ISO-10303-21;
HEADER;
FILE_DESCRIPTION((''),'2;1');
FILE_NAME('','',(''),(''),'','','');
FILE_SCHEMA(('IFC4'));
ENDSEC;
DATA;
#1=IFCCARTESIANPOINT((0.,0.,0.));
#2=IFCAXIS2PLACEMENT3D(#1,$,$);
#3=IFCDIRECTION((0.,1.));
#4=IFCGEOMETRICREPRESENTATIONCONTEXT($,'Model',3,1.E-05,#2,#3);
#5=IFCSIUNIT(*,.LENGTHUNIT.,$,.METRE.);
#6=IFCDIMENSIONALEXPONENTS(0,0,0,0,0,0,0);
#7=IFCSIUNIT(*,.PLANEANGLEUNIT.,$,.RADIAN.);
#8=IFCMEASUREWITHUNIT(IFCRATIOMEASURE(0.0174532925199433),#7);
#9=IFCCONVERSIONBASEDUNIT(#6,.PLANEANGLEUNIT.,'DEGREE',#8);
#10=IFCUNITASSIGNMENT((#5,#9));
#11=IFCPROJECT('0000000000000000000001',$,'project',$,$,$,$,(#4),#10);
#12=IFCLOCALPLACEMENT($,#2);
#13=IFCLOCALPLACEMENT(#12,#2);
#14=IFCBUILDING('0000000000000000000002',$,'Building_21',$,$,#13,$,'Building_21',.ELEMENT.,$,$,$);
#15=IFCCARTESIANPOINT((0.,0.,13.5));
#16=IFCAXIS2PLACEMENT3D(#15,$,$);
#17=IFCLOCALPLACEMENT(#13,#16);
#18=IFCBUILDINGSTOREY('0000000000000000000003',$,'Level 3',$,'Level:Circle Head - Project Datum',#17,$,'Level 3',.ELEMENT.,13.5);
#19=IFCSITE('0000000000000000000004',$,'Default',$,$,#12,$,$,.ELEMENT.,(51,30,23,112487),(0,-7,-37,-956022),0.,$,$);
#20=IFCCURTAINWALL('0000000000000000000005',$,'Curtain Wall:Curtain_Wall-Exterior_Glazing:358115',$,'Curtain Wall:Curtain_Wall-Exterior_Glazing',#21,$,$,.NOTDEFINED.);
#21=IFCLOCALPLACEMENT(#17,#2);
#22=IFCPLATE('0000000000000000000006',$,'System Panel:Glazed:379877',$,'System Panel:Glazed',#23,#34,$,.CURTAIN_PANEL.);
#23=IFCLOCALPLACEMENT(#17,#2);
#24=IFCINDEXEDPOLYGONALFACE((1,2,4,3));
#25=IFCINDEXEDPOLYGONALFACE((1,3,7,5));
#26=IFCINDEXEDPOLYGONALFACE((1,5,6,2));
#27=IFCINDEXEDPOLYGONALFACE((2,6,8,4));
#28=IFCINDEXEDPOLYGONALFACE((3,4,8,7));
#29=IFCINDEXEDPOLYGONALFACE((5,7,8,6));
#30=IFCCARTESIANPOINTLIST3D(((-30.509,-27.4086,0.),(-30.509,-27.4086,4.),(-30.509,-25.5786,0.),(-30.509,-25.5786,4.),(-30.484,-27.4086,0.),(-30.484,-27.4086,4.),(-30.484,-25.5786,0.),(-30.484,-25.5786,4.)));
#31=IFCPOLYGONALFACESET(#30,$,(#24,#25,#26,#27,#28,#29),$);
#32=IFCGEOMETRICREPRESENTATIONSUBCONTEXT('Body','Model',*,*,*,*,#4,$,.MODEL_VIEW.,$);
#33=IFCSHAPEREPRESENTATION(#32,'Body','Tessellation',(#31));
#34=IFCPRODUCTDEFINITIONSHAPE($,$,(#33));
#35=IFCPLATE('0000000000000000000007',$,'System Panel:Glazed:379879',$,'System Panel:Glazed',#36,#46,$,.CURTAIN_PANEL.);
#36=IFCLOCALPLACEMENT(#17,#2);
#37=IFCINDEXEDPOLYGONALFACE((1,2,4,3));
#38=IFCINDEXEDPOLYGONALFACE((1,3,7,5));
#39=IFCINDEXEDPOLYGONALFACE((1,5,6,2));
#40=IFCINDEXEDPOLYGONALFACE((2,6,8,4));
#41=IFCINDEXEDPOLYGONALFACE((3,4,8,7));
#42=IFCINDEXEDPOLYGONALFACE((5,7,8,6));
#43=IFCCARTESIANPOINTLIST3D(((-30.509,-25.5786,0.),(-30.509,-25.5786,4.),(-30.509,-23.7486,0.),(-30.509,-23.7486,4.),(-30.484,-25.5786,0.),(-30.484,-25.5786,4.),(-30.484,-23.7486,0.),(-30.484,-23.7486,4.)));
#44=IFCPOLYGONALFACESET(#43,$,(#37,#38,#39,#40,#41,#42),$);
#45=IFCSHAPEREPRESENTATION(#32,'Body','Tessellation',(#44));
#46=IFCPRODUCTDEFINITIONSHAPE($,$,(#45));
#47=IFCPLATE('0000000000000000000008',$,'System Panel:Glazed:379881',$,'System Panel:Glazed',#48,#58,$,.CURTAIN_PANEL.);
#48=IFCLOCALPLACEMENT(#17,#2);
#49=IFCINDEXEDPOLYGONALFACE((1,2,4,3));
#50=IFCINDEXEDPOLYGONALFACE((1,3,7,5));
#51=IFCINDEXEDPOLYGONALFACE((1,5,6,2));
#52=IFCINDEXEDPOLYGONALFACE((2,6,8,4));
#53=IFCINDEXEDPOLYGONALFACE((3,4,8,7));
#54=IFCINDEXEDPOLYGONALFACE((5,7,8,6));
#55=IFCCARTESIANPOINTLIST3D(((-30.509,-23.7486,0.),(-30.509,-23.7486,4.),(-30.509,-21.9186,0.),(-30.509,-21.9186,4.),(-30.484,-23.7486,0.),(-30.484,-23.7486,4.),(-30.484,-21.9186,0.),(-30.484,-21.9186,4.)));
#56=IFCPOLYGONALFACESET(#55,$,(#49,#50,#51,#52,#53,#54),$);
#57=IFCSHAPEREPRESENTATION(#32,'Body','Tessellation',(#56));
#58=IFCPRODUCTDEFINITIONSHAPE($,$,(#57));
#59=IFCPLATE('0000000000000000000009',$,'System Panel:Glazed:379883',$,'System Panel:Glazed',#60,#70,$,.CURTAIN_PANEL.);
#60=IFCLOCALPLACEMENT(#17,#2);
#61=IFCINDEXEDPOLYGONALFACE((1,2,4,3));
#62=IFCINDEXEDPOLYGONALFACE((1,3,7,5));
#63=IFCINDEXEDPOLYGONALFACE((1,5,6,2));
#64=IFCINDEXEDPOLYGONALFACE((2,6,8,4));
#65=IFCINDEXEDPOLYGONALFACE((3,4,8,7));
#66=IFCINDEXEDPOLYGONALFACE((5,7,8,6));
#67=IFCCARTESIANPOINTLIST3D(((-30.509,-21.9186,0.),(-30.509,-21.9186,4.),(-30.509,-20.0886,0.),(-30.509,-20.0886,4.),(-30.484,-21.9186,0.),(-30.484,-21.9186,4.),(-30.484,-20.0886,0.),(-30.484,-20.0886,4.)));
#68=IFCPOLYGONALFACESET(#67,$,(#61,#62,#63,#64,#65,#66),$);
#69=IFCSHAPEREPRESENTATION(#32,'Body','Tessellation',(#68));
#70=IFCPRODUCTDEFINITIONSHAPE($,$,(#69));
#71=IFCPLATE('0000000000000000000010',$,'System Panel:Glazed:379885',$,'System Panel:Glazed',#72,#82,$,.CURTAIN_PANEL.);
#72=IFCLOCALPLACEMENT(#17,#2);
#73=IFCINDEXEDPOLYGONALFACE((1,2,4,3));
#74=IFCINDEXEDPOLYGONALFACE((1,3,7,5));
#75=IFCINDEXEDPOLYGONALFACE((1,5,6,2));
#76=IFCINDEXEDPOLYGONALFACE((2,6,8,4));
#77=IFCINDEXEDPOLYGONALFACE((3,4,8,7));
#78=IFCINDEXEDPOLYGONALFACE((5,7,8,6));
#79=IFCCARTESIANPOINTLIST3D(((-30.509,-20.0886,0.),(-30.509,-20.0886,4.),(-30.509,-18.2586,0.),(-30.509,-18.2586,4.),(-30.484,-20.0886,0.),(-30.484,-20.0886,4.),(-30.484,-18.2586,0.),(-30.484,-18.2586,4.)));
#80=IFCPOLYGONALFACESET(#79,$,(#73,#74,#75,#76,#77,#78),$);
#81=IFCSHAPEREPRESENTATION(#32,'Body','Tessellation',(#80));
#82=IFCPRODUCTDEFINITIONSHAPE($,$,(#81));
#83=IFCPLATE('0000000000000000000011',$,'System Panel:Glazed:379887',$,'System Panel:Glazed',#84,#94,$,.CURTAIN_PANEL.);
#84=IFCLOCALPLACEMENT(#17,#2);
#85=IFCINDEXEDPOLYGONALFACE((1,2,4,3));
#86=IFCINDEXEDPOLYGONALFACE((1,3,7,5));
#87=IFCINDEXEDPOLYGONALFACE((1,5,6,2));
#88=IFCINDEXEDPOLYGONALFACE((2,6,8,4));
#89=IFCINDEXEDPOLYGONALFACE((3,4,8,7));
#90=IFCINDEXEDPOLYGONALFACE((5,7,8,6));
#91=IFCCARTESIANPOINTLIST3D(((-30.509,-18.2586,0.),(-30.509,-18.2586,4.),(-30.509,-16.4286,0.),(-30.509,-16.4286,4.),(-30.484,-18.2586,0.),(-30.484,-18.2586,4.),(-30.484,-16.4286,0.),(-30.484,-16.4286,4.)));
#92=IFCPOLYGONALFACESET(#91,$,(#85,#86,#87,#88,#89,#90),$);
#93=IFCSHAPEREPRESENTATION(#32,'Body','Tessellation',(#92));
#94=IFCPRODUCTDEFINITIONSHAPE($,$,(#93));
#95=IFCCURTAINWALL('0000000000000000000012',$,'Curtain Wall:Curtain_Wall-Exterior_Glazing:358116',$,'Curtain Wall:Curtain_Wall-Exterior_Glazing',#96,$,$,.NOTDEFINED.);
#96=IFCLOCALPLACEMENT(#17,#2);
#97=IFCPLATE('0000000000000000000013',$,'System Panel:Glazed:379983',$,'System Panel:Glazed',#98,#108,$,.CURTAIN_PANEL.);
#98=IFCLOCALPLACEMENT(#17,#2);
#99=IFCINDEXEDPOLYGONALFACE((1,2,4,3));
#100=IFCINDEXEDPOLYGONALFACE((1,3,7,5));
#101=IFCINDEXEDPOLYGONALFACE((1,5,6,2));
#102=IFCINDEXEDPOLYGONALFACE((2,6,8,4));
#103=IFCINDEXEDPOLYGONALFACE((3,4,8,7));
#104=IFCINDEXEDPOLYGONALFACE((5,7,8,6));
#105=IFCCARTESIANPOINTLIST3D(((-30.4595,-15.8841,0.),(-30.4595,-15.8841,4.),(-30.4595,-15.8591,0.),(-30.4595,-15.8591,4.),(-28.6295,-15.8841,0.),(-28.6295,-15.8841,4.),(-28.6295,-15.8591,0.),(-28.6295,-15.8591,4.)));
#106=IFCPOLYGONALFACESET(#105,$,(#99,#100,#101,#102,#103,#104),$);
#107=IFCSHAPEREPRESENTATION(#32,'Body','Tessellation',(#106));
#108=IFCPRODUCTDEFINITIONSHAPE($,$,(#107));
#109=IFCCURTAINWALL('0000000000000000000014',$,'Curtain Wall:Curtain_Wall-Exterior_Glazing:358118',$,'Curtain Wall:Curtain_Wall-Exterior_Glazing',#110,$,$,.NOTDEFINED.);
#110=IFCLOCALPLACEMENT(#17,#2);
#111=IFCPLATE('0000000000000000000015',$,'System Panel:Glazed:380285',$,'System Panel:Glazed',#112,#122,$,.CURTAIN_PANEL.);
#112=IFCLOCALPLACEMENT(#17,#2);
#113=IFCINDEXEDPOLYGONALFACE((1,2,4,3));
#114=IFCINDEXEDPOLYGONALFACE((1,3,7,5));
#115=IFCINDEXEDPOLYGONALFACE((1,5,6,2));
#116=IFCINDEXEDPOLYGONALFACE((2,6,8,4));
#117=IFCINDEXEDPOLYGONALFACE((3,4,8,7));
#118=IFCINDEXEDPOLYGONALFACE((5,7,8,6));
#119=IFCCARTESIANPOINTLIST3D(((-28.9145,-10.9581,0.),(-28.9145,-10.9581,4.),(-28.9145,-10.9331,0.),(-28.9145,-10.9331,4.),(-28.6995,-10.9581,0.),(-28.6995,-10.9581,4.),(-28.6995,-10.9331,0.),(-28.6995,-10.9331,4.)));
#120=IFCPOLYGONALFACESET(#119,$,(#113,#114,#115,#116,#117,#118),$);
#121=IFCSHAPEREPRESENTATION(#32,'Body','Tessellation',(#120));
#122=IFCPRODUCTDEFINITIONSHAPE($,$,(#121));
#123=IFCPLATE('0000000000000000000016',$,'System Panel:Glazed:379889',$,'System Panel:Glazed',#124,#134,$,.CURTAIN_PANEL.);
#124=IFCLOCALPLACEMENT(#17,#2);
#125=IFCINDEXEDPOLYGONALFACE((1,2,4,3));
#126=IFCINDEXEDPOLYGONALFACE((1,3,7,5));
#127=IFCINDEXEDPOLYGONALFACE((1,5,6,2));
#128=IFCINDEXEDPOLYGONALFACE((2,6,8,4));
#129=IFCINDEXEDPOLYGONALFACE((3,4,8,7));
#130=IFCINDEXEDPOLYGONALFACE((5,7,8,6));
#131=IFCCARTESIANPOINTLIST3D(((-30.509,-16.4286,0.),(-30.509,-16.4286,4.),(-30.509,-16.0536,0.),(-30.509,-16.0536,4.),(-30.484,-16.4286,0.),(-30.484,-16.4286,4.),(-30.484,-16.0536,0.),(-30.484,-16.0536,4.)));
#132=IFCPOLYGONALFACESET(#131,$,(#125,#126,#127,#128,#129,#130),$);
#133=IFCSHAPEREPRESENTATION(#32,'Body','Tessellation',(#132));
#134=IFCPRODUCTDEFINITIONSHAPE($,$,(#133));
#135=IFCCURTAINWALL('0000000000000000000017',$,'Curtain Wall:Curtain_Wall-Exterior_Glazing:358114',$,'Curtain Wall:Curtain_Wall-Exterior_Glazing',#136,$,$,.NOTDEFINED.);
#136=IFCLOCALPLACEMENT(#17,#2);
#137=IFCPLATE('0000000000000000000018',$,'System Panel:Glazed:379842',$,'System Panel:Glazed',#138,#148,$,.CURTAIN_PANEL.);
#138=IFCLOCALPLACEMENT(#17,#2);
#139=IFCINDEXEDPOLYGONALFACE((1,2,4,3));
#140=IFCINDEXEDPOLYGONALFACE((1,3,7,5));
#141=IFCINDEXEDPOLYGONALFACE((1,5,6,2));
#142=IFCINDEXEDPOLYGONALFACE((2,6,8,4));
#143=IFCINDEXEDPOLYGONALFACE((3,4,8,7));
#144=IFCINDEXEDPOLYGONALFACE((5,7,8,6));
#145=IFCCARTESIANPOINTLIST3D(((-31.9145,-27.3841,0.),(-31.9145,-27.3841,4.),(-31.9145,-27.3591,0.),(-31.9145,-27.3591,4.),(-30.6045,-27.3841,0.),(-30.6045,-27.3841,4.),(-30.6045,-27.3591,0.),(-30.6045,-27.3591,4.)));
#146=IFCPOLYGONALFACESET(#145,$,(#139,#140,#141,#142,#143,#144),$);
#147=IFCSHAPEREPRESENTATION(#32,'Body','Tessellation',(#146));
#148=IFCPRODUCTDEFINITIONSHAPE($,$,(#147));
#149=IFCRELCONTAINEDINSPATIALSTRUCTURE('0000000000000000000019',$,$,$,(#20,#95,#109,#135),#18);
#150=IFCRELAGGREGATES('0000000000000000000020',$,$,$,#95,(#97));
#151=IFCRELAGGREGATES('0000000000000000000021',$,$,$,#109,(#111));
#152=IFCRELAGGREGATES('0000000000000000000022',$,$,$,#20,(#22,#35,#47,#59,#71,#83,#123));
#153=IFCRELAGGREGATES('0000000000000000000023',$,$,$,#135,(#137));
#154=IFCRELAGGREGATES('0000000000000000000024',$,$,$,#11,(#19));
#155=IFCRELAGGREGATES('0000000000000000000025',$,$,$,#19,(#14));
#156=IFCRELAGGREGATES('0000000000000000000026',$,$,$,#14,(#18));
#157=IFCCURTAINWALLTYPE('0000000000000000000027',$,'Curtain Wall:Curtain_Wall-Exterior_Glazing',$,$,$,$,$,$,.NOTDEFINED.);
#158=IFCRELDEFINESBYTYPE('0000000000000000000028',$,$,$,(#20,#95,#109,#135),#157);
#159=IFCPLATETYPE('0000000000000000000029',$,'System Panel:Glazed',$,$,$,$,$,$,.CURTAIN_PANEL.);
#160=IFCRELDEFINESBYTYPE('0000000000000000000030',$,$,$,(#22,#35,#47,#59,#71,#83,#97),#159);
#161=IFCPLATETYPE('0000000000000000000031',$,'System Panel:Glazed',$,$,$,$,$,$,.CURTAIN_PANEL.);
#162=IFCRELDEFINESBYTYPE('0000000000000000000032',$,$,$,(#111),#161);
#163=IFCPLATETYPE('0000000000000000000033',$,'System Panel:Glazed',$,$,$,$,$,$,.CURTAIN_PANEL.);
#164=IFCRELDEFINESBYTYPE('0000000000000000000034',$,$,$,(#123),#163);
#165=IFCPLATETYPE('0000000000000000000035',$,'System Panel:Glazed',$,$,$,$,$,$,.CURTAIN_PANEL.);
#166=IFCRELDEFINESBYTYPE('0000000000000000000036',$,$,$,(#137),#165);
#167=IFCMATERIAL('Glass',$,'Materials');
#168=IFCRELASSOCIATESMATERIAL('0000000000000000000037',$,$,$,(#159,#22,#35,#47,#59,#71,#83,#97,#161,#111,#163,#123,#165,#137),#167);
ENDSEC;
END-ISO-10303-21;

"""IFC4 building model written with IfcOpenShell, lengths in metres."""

from ifc_helpers import new_model, entity, si_unit, converted_unit, direction, frame, origin, origin_2d_with_axis, place, context, subcontext, project, spatial, rectangle, extrude, source, transform, mapped, material, type_object, type_shapes, element, aggregate, save


model = new_model("IFC4")

# Units and contexts
model_context = context("Model", 3, precision=1e-05, world=origin(), true_north=direction((0.0, 1.0)))
body_context = subcontext(model_context, "Body", "Model", "MODEL_VIEW")
ifc_project = project(units=[si_unit("LENGTHUNIT", "METRE"), converted_unit("PLANEANGLEUNIT", "DEGREE", entity("IfcRatioMeasure", 0.0174532925199433), si_unit("PLANEANGLEUNIT", "RADIAN"), dimensions=[0, 0, 0, 0, 0, 0, 0])], contexts=[model_context])

# Site, building, storey
site_placement = place(None, origin())
site = spatial("IfcSite", under=ifc_project, at=site_placement, Name="Default", CompositionType="ELEMENT", RefLatitude=(51, 30, 23, 112487), RefLongitude=(0, -7, -37, -956022), RefElevation=0.0)
building_placement = place(site_placement, origin())
building = spatial("IfcBuilding", under=site, at=building_placement, Name="Building_21", LongName="Building_21", CompositionType="ELEMENT")
storey_placement = place(building_placement, frame((0.0, 0.0, 13.5)))
storey = spatial("IfcBuildingStorey", under=building, at=storey_placement, Name="Level 3", ObjectType="Level:Circle Head - Project Datum", LongName="Level 3", CompositionType="ELEMENT", Elevation=13.5)

# Curtain wall, plates
curtain_wall_type = type_object("IfcCurtainWallType", Name="Curtain Wall:Curtain_Wall-Exterior_Glazing", PredefinedType="NOTDEFINED")
curtain_wall_1_placement = place(storey_placement, frame((0.0, 0.0, -13.5)))
curtain_wall_1 = element("IfcCurtainWall", 1, at=curtain_wall_1_placement, inside=storey, type_object=curtain_wall_type, Name="Curtain Wall:Curtain_Wall-Exterior_Glazing:358115", ObjectType="Curtain Wall:Curtain_Wall-Exterior_Glazing", PredefinedType="NOTDEFINED")
ifc_material_1 = material(Name="Glass", Category="Materials")
plate_type_1 = type_object("IfcPlateType", Name="System Panel:Glazed", PredefinedType="CURTAIN_PANEL", material=ifc_material_1)
shared_shape_1 = source(origin(), body_context, "Body", "SweptSolid", [
    extrude(rectangle(XDim=0.025, YDim=1.83, at=origin_2d_with_axis()), frame((0.915, 0.0125, 0.0), z_axis=(0.0, 0.0, 1.0), x_axis=(0.0, 1.0, 0.0)), (0.0, 0.0, 1.0), 4.0),
])
type_shapes(plate_type_1, [shared_shape_1])
plate_1_placement = place(curtain_wall_1_placement, frame((-30.484, -27.4086, 13.5), z_axis=(0.0, 0.0, 1.0), x_axis=(0.0, 1.0, 0.0)))
plate_1 = element("IfcPlate", 2, at=plate_1_placement, type_object=plate_type_1, material=ifc_material_1, Name="System Panel:Glazed:379877", ObjectType="System Panel:Glazed", PredefinedType="CURTAIN_PANEL", context=body_context, shape_type="MappedRepresentation", body=[
    mapped(shared_shape_1, transform((0.0, 0.0, 0.0), scale=1.0)),
])
plate_2_placement = place(curtain_wall_1_placement, frame((-30.484, -25.5786, 13.5), z_axis=(0.0, 0.0, 1.0), x_axis=(0.0, 1.0, 0.0)))
plate_2 = element("IfcPlate", 3, at=plate_2_placement, type_object=plate_type_1, material=ifc_material_1, Name="System Panel:Glazed:379879", ObjectType="System Panel:Glazed", PredefinedType="CURTAIN_PANEL", context=body_context, shape_type="MappedRepresentation", body=[
    mapped(shared_shape_1, transform((0.0, 0.0, 0.0), scale=1.0)),
])
plate_3_placement = place(curtain_wall_1_placement, frame((-30.484, -23.7486, 13.5), z_axis=(0.0, 0.0, 1.0), x_axis=(0.0, 1.0, 0.0)))
plate_3 = element("IfcPlate", 4, at=plate_3_placement, type_object=plate_type_1, material=ifc_material_1, Name="System Panel:Glazed:379881", ObjectType="System Panel:Glazed", PredefinedType="CURTAIN_PANEL", context=body_context, shape_type="MappedRepresentation", body=[
    mapped(shared_shape_1, transform((0.0, 0.0, 0.0), scale=1.0)),
])
plate_4_placement = place(curtain_wall_1_placement, frame((-30.484, -21.9186, 13.5), z_axis=(0.0, 0.0, 1.0), x_axis=(0.0, 1.0, 0.0)))
plate_4 = element("IfcPlate", 5, at=plate_4_placement, type_object=plate_type_1, material=ifc_material_1, Name="System Panel:Glazed:379883", ObjectType="System Panel:Glazed", PredefinedType="CURTAIN_PANEL", context=body_context, shape_type="MappedRepresentation", body=[
    mapped(shared_shape_1, transform((0.0, 0.0, 0.0), scale=1.0)),
])
plate_5_placement = place(curtain_wall_1_placement, frame((-30.484, -20.0886, 13.5), z_axis=(0.0, 0.0, 1.0), x_axis=(0.0, 1.0, 0.0)))
plate_5 = element("IfcPlate", 6, at=plate_5_placement, type_object=plate_type_1, material=ifc_material_1, Name="System Panel:Glazed:379885", ObjectType="System Panel:Glazed", PredefinedType="CURTAIN_PANEL", context=body_context, shape_type="MappedRepresentation", body=[
    mapped(shared_shape_1, transform((0.0, 0.0, 0.0), scale=1.0)),
])
plate_6_placement = place(curtain_wall_1_placement, frame((-30.484, -18.2586, 13.5), z_axis=(0.0, 0.0, 1.0), x_axis=(0.0, 1.0, 0.0)))
plate_6 = element("IfcPlate", 7, at=plate_6_placement, type_object=plate_type_1, material=ifc_material_1, Name="System Panel:Glazed:379887", ObjectType="System Panel:Glazed", PredefinedType="CURTAIN_PANEL", context=body_context, shape_type="MappedRepresentation", body=[
    mapped(shared_shape_1, transform((0.0, 0.0, 0.0), scale=1.0)),
])

# Curtain walls, plates
curtain_wall_2_placement = place(storey_placement, frame((0.0, 0.0, -13.5)))
curtain_wall_2 = element("IfcCurtainWall", 8, at=curtain_wall_2_placement, inside=storey, type_object=curtain_wall_type, Name="Curtain Wall:Curtain_Wall-Exterior_Glazing:358116", ObjectType="Curtain Wall:Curtain_Wall-Exterior_Glazing", PredefinedType="NOTDEFINED")
plate_7_placement = place(curtain_wall_2_placement, frame((-30.4595, -15.8841, 13.5)))
plate_7 = element("IfcPlate", 9, at=plate_7_placement, type_object=plate_type_1, material=ifc_material_1, Name="System Panel:Glazed:379983", ObjectType="System Panel:Glazed", PredefinedType="CURTAIN_PANEL", context=body_context, shape_type="MappedRepresentation", body=[
    mapped(shared_shape_1, transform((0.0, 0.0, 0.0), scale=1.0)),
])
aggregate(curtain_wall_2, [plate_7])
curtain_wall_3_placement = place(storey_placement, frame((0.0, 0.0, -13.5)))
curtain_wall_3 = element("IfcCurtainWall", 10, at=curtain_wall_3_placement, inside=storey, type_object=curtain_wall_type, Name="Curtain Wall:Curtain_Wall-Exterior_Glazing:358118", ObjectType="Curtain Wall:Curtain_Wall-Exterior_Glazing", PredefinedType="NOTDEFINED")
plate_type_2 = type_object("IfcPlateType", Name="System Panel:Glazed", PredefinedType="CURTAIN_PANEL", material=ifc_material_1)
shared_shape_2 = source(origin(), body_context, "Body", "SweptSolid", [
    extrude(rectangle(XDim=0.025, YDim=0.215, at=origin_2d_with_axis()), frame((0.1075, 0.0125, 0.0), z_axis=(0.0, 0.0, 1.0), x_axis=(0.0, 1.0, 0.0)), (0.0, 0.0, 1.0), 4.0),
])
type_shapes(plate_type_2, [shared_shape_2])
plate_8_placement = place(curtain_wall_3_placement, frame((-28.6995, -10.9331, 13.5), z_axis=(0.0, 0.0, 1.0), x_axis=(-1.0, 0.0, 0.0)))
plate_8 = element("IfcPlate", 11, at=plate_8_placement, type_object=plate_type_2, material=ifc_material_1, Name="System Panel:Glazed:380285", ObjectType="System Panel:Glazed", PredefinedType="CURTAIN_PANEL", context=body_context, shape_type="MappedRepresentation", body=[
    mapped(shared_shape_2, transform((0.0, 0.0, 0.0), scale=1.0)),
])
aggregate(curtain_wall_3, [plate_8])

# Plate
plate_type_3 = type_object("IfcPlateType", Name="System Panel:Glazed", PredefinedType="CURTAIN_PANEL", material=ifc_material_1)
shared_shape_3 = source(origin(), body_context, "Body", "SweptSolid", [
    extrude(rectangle(XDim=0.025, YDim=0.375, at=origin_2d_with_axis()), frame((0.1875, 0.0125, 0.0), z_axis=(0.0, 0.0, 1.0), x_axis=(0.0, 1.0, 0.0)), (0.0, 0.0, 1.0), 4.0),
])
type_shapes(plate_type_3, [shared_shape_3])
plate_9_placement = place(curtain_wall_1_placement, frame((-30.484, -16.4286, 13.5), z_axis=(0.0, 0.0, 1.0), x_axis=(0.0, 1.0, 0.0)))
plate_9 = element("IfcPlate", 12, at=plate_9_placement, type_object=plate_type_3, material=ifc_material_1, Name="System Panel:Glazed:379889", ObjectType="System Panel:Glazed", PredefinedType="CURTAIN_PANEL", context=body_context, shape_type="MappedRepresentation", body=[
    mapped(shared_shape_3, transform((0.0, 0.0, 0.0), scale=1.0)),
])
aggregate(curtain_wall_1, [plate_1, plate_2, plate_3, plate_4, plate_5, plate_6, plate_9])

# Curtain wall, plate
curtain_wall_4_placement = place(storey_placement, frame((0.0, 0.0, -13.5)))
curtain_wall_4 = element("IfcCurtainWall", 13, at=curtain_wall_4_placement, inside=storey, type_object=curtain_wall_type, Name="Curtain Wall:Curtain_Wall-Exterior_Glazing:358114", ObjectType="Curtain Wall:Curtain_Wall-Exterior_Glazing", PredefinedType="NOTDEFINED")
plate_type_4 = type_object("IfcPlateType", Name="System Panel:Glazed", PredefinedType="CURTAIN_PANEL", material=ifc_material_1)
shared_shape_4 = source(origin(), body_context, "Body", "SweptSolid", [
    extrude(rectangle(XDim=0.025, YDim=1.31, at=origin_2d_with_axis()), frame((0.655, 0.0125, 0.0), z_axis=(0.0, 0.0, 1.0), x_axis=(0.0, 1.0, 0.0)), (0.0, 0.0, 1.0), 4.0),
])
type_shapes(plate_type_4, [shared_shape_4])
plate_10_placement = place(curtain_wall_4_placement, frame((-31.9145, -27.3841, 13.5)))
plate_10 = element("IfcPlate", 14, at=plate_10_placement, type_object=plate_type_4, material=ifc_material_1, Name="System Panel:Glazed:379842", ObjectType="System Panel:Glazed", PredefinedType="CURTAIN_PANEL", context=body_context, shape_type="MappedRepresentation", body=[
    mapped(shared_shape_4, transform((0.0, 0.0, 0.0), scale=1.0)),
])
aggregate(curtain_wall_4, [plate_10])

save(model, "model.ifc")
